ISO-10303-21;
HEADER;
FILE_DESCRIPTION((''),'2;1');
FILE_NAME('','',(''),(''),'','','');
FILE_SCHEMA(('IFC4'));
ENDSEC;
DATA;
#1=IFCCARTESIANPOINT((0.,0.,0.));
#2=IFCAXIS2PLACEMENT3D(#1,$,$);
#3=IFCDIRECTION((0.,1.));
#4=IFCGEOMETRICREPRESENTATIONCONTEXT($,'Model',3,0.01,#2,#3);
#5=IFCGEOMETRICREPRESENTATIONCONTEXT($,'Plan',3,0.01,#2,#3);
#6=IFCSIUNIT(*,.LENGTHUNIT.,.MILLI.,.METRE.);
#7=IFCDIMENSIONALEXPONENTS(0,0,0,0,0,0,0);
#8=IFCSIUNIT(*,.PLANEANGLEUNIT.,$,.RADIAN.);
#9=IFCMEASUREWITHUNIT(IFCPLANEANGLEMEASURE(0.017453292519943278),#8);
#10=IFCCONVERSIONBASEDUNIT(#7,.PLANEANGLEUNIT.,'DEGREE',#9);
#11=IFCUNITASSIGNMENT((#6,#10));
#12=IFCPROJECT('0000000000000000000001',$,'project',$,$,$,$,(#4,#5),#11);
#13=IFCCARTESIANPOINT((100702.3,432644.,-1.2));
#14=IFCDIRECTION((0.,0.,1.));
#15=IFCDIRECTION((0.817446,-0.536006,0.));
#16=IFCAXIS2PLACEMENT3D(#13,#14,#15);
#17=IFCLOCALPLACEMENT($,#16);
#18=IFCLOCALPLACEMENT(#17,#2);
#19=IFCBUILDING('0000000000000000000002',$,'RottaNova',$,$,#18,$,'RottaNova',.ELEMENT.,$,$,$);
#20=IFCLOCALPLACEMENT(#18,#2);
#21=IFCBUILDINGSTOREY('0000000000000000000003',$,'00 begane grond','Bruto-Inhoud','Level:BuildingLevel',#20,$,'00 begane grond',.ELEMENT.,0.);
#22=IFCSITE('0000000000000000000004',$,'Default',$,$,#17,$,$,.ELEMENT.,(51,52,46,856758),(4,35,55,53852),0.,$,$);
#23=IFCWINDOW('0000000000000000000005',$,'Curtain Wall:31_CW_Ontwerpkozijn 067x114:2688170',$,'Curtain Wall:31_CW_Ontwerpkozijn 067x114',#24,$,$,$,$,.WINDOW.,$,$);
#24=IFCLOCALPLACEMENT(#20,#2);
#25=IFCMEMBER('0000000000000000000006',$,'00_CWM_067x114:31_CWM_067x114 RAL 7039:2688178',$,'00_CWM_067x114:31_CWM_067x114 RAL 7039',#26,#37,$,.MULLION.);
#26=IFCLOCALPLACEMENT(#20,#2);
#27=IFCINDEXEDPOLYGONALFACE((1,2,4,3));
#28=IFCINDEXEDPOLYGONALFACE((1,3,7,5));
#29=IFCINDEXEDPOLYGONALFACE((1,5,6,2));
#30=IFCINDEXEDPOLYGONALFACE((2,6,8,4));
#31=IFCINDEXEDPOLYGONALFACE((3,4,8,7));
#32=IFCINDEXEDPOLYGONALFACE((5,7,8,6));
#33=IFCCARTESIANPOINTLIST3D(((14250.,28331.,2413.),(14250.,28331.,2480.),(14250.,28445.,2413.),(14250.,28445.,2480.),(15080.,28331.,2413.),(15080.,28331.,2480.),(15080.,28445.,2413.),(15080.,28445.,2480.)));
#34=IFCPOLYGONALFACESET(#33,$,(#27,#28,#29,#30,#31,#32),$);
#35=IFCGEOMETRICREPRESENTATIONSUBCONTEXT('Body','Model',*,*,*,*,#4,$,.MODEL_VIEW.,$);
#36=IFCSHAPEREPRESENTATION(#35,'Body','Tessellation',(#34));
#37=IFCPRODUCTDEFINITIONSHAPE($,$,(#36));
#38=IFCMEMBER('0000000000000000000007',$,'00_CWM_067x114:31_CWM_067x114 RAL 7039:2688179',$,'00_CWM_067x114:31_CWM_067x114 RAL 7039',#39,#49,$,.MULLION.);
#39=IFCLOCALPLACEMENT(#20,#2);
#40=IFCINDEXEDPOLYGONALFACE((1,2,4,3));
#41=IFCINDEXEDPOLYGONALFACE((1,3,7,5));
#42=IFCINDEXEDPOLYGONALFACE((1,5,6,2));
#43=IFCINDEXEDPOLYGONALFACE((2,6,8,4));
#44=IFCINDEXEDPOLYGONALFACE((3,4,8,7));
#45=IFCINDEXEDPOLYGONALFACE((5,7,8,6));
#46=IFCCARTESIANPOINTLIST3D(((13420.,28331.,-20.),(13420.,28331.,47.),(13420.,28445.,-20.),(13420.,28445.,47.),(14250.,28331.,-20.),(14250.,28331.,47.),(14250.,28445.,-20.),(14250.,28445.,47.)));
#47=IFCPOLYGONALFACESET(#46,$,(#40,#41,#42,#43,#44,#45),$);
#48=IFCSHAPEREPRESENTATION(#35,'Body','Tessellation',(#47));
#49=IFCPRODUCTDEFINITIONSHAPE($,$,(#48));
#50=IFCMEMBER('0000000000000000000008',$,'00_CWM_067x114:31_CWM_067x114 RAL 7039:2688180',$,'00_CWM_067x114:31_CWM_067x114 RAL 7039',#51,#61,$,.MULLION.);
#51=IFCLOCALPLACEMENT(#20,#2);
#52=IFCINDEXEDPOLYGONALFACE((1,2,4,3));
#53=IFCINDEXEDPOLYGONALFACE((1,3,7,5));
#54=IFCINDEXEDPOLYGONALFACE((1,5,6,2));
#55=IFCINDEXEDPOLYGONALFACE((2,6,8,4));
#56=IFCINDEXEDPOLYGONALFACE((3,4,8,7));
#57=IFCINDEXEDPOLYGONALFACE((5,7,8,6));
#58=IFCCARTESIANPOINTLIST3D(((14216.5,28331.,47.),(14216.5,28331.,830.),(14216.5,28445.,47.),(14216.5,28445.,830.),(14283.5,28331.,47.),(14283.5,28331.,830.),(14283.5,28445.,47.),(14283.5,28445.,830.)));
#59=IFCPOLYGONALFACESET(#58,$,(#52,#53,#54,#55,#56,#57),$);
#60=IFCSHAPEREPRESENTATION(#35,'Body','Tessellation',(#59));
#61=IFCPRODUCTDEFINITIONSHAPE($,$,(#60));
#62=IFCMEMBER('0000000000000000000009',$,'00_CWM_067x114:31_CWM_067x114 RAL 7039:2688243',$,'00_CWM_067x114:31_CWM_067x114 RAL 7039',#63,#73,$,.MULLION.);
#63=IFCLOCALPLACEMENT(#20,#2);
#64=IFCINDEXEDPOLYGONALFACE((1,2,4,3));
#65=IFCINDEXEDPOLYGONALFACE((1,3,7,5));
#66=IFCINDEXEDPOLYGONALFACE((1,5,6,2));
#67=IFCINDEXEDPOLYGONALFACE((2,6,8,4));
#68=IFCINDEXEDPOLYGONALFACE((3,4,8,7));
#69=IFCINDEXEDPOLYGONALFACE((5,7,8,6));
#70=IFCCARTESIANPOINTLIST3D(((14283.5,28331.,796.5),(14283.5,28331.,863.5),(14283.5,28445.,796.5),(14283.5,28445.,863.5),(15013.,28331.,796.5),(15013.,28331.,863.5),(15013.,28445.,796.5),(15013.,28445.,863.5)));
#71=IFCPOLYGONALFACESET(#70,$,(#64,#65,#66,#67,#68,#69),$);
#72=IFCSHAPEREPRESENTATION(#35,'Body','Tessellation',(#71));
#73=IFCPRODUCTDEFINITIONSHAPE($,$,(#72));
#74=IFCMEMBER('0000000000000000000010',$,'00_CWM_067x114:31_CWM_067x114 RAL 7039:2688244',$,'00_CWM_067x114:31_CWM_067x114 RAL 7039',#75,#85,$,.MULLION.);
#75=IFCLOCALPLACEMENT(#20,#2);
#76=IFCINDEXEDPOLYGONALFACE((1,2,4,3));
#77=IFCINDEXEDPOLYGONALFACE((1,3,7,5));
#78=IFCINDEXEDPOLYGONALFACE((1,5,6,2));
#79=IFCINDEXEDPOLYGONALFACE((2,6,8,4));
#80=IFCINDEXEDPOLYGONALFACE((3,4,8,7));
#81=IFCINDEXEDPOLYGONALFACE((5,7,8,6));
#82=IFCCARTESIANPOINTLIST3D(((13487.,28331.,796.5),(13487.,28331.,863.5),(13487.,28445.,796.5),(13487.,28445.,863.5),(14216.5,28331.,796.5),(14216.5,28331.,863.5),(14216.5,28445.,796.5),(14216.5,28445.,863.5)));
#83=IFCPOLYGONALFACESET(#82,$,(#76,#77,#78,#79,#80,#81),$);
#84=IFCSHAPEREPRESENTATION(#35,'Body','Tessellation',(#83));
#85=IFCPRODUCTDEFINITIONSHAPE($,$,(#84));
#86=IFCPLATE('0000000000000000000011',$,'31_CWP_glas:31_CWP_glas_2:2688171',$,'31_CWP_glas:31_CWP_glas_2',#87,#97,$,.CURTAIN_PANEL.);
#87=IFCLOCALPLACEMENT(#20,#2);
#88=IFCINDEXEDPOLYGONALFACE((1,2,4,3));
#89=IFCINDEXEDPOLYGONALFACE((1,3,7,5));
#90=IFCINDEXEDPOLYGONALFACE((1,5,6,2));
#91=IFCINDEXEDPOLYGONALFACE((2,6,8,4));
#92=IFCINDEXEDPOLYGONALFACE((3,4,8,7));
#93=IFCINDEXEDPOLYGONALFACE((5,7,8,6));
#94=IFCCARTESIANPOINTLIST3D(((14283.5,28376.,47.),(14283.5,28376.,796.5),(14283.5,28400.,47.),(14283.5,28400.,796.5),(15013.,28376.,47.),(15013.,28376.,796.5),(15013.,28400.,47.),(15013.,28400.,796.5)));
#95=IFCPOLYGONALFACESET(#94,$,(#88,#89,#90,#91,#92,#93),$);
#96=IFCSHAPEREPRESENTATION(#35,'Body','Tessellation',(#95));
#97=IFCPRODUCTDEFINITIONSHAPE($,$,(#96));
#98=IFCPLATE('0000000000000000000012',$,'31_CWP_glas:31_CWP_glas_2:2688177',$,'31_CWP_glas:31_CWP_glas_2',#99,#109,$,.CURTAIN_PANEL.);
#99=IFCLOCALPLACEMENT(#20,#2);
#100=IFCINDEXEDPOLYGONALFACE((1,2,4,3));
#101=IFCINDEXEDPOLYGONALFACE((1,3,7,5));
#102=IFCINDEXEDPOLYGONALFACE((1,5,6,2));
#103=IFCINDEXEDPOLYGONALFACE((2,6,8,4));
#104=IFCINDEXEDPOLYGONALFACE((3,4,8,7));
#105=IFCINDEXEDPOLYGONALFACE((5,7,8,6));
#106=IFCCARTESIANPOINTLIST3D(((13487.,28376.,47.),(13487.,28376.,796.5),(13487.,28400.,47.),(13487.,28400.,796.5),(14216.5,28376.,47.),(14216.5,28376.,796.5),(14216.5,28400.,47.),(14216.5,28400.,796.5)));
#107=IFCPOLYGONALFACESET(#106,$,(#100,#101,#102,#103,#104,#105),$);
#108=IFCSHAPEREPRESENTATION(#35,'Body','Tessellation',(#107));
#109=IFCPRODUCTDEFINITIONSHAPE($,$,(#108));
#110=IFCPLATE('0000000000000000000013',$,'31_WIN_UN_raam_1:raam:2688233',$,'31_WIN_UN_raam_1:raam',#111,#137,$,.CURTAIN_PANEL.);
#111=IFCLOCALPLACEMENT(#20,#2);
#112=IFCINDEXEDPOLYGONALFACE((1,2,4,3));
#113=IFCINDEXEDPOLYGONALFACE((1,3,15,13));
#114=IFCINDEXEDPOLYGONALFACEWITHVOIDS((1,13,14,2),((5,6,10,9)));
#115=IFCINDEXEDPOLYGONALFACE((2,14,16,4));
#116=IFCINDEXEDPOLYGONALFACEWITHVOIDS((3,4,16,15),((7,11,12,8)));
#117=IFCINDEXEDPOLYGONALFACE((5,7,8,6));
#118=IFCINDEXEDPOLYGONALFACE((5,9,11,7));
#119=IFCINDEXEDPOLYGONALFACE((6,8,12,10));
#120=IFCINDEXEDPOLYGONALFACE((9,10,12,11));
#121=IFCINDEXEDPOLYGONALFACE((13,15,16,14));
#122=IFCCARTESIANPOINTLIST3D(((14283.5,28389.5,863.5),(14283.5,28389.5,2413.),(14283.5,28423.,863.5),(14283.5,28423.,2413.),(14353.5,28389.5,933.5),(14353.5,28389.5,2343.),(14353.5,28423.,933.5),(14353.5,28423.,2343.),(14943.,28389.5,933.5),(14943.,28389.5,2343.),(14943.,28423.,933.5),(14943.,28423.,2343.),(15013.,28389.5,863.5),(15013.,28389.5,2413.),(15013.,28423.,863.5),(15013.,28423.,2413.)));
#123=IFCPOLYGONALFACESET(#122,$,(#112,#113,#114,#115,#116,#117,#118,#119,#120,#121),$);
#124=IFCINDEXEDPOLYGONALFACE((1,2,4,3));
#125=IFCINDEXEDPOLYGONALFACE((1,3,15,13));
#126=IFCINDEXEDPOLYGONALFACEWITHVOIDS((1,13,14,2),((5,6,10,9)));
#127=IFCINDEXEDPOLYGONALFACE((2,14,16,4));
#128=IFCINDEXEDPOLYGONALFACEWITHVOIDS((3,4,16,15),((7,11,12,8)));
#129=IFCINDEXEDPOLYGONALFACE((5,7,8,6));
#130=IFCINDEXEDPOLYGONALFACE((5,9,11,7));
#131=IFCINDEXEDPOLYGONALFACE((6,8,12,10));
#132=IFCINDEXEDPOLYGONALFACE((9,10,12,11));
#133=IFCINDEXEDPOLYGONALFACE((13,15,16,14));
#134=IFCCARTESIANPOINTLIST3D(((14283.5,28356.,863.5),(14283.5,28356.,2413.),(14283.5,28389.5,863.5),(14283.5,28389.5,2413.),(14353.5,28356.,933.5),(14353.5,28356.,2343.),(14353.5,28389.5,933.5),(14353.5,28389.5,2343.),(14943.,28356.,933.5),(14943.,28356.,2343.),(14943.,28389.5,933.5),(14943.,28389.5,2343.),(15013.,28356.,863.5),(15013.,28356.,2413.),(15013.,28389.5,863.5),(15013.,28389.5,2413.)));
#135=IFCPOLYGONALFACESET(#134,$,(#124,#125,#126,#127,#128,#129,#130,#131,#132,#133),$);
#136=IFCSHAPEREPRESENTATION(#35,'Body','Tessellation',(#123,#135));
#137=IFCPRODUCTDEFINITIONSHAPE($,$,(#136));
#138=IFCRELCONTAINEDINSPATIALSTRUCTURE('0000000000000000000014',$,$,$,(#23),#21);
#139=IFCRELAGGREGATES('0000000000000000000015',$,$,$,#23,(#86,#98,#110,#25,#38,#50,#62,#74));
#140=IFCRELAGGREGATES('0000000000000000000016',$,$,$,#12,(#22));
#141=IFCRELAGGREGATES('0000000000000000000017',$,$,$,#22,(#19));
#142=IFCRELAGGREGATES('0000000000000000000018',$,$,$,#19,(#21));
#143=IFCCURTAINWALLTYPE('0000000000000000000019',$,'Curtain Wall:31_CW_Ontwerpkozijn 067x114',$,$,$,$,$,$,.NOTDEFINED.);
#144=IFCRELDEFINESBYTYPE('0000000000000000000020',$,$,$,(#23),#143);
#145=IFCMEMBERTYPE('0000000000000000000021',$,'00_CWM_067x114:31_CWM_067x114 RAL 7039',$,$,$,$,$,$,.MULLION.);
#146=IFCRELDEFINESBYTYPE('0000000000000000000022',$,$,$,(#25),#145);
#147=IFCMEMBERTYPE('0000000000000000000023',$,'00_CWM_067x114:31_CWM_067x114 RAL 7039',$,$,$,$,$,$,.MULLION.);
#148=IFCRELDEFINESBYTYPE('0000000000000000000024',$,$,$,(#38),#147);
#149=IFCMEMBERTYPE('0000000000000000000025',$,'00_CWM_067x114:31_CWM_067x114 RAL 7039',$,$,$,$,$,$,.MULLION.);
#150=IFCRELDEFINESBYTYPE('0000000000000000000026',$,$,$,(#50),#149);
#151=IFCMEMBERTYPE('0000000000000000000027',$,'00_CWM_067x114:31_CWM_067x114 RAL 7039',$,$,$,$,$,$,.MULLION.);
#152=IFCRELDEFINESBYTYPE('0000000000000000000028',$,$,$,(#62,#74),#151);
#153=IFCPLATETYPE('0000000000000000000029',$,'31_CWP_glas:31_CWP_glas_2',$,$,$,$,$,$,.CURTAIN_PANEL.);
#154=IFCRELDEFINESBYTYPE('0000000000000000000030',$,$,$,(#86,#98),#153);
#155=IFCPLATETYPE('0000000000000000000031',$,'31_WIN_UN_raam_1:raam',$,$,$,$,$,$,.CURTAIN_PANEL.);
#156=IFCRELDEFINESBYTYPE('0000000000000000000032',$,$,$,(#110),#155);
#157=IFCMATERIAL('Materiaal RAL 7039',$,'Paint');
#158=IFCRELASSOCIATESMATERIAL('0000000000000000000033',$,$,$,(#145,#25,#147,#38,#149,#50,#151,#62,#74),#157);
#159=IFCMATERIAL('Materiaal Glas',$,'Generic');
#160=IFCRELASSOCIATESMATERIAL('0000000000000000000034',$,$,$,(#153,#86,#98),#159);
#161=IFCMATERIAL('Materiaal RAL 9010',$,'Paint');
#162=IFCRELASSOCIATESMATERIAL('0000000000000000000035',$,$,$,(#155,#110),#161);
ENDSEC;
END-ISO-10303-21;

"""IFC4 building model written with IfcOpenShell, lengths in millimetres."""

from ifc_helpers import new_model, entity, si_unit, converted_unit, direction, frame, origin, place, context, subcontext, project, spatial, indexed_curve, outline, extrude, source, transform, mapped, material, type_object, type_shapes, element, aggregate, save


model = new_model("IFC4")

# Units and contexts
model_context = context("Model", 3, precision=0.01, world=origin(), true_north=direction((0.0, 1.0)))
plan_context = context("Plan", 3, precision=0.01, world=origin(), true_north=direction((0.0, 1.0)))
body_context = subcontext(model_context, "Body", "Model", "MODEL_VIEW")
ifc_project = project(units=[si_unit("LENGTHUNIT", "METRE", prefix="MILLI"), converted_unit("PLANEANGLEUNIT", "DEGREE", entity("IfcPlaneAngleMeasure", 0.017453292519943278), si_unit("PLANEANGLEUNIT", "RADIAN"), dimensions=[0, 0, 0, 0, 0, 0, 0])], contexts=[model_context, plan_context])

# Site, building, storey
site_placement = place(None, frame((100702.3, 432644.0, -1.2), z_axis=(0.0, 0.0, 1.0), x_axis=(0.817446, -0.536006, 0.0)))
site = spatial("IfcSite", under=ifc_project, at=site_placement, Name="Default", CompositionType="ELEMENT", RefLatitude=(51, 52, 46, 856758), RefLongitude=(4, 35, 55, 53852), RefElevation=0.0)
building_placement = place(site_placement, origin())
building = spatial("IfcBuilding", under=site, at=building_placement, Name="RottaNova", LongName="RottaNova", CompositionType="ELEMENT")
storey_placement = place(building_placement, origin())
storey = spatial("IfcBuildingStorey", under=building, at=storey_placement, Name="00 begane grond", Description="Bruto-Inhoud", ObjectType="Level:BuildingLevel", LongName="00 begane grond", CompositionType="ELEMENT", Elevation=0.0)

# Shared definitions
curtain_wall_type = type_object("IfcCurtainWallType", Name="Curtain Wall:31_CW_Ontwerpkozijn 067x114", PredefinedType="NOTDEFINED")
ifc_material_1 = material(Name="Materiaal RAL 7039", Category="Paint")

# Window
window_1_placement = place(storey_placement, origin())
window_1 = element("IfcWindow", 1, at=window_1_placement, inside=storey, type_object=curtain_wall_type, Name="Curtain Wall:31_CW_Ontwerpkozijn 067x114:2688170", ObjectType="Curtain Wall:31_CW_Ontwerpkozijn 067x114", PredefinedType="WINDOW")

# Members
member_type_1 = type_object("IfcMemberType", Name="00_CWM_067x114:31_CWM_067x114 RAL 7039", PredefinedType="MULLION", material=ifc_material_1)
shared_shape_1 = source(origin(), body_context, "Body", "SweptSolid", [
    extrude(outline(indexed_curve([(-33.5, -57.0), (33.5, -57.0), (33.5, 57.0), (-33.5, 57.0), (-33.5, -57.0)], self_intersect=False)), frame((-33.5, 57.0, -830.0), z_axis=(0.0, 0.0, 1.0), x_axis=(-1.0, 0.0, 0.0)), (0.0, 0.0, 1.0), 830.0),
])
type_shapes(member_type_1, [shared_shape_1])
member_1_placement = place(window_1_placement, frame((14250.0, 28331.0, 2480.0), z_axis=(-1.0, 0.0, 0.0), x_axis=(0.0, 0.0, 1.0)))
member_1 = element("IfcMember", 2, at=member_1_placement, type_object=member_type_1, material=ifc_material_1, Name="00_CWM_067x114:31_CWM_067x114 RAL 7039:2688178", ObjectType="00_CWM_067x114:31_CWM_067x114 RAL 7039", PredefinedType="MULLION", context=body_context, shape_type="MappedRepresentation", body=[
    mapped(shared_shape_1, transform((0.0, 0.0, 0.0), scale=1.0)),
])
member_type_2 = type_object("IfcMemberType", Name="00_CWM_067x114:31_CWM_067x114 RAL 7039", PredefinedType="MULLION", material=ifc_material_1)
shared_shape_2 = source(origin(), body_context, "Body", "SweptSolid", [
    extrude(outline(indexed_curve([(-33.5, -57.0), (33.5, -57.0), (33.5, 57.0), (-33.5, 57.0), (-33.5, -57.0)], self_intersect=False)), frame((-33.5, 57.0, -830.0), z_axis=(0.0, 0.0, 1.0), x_axis=(-1.0, 0.0, 0.0)), (0.0, 0.0, 1.0), 830.0),
])
type_shapes(member_type_2, [shared_shape_2])
member_2_placement = place(window_1_placement, frame((14250.0, 28331.0, -20.0), z_axis=(1.0, 0.0, 0.0), x_axis=(0.0, 0.0, -1.0)))
member_2 = element("IfcMember", 3, at=member_2_placement, type_object=member_type_2, material=ifc_material_1, Name="00_CWM_067x114:31_CWM_067x114 RAL 7039:2688179", ObjectType="00_CWM_067x114:31_CWM_067x114 RAL 7039", PredefinedType="MULLION", context=body_context, shape_type="MappedRepresentation", body=[
    mapped(shared_shape_2, transform((0.0, 0.0, 0.0), scale=1.0)),
])
member_type_3 = type_object("IfcMemberType", Name="00_CWM_067x114:31_CWM_067x114 RAL 7039", PredefinedType="MULLION", material=ifc_material_1)
shared_shape_3 = source(origin(), body_context, "Body", "SweptSolid", [
    extrude(outline(indexed_curve([(-33.5, -57.0), (33.5, -57.0), (33.5, 57.0), (-33.5, 57.0), (-33.5, -57.0)], self_intersect=False)), frame((0.0, 57.0, -783.0), z_axis=(0.0, 0.0, 1.0), x_axis=(-1.0, 0.0, 0.0)), (0.0, 0.0, 1.0), 783.0),
])
type_shapes(member_type_3, [shared_shape_3])
member_3_placement = place(window_1_placement, frame((14250.0, 28331.0, 47.0), z_axis=(0.0, 0.0, -1.0), x_axis=(-1.0, 0.0, 0.0)))
member_3 = element("IfcMember", 4, at=member_3_placement, type_object=member_type_3, material=ifc_material_1, Name="00_CWM_067x114:31_CWM_067x114 RAL 7039:2688180", ObjectType="00_CWM_067x114:31_CWM_067x114 RAL 7039", PredefinedType="MULLION", context=body_context, shape_type="MappedRepresentation", body=[
    mapped(shared_shape_3, transform((0.0, 0.0, 0.0), scale=1.0)),
])
member_type_4 = type_object("IfcMemberType", Name="00_CWM_067x114:31_CWM_067x114 RAL 7039", PredefinedType="MULLION", material=ifc_material_1)
shared_shape_4 = source(origin(), body_context, "Body", "SweptSolid", [
    extrude(outline(indexed_curve([(-33.5, -57.0), (33.5, -57.0), (33.5, 57.0), (-33.5, 57.0), (-33.5, -57.0)], self_intersect=False)), frame((0.0, 57.0, -729.5), z_axis=(0.0, 0.0, 1.0), x_axis=(-1.0, 0.0, 0.0)), (0.0, 0.0, 1.0), 729.5),
])
type_shapes(member_type_4, [shared_shape_4])
member_4_placement = place(window_1_placement, frame((14283.5, 28331.0, 830.0), z_axis=(-1.0, 0.0, 0.0), x_axis=(0.0, 0.0, 1.0)))
member_4 = element("IfcMember", 5, at=member_4_placement, type_object=member_type_4, material=ifc_material_1, Name="00_CWM_067x114:31_CWM_067x114 RAL 7039:2688243", ObjectType="00_CWM_067x114:31_CWM_067x114 RAL 7039", PredefinedType="MULLION", context=body_context, shape_type="MappedRepresentation", body=[
    mapped(shared_shape_4, transform((0.0, 0.0, 0.0), scale=1.0)),
])
member_5_placement = place(window_1_placement, frame((13487.0, 28331.0, 830.0), z_axis=(-1.0, 0.0, 0.0), x_axis=(0.0, 0.0, 1.0)))
member_5 = element("IfcMember", 6, at=member_5_placement, type_object=member_type_4, material=ifc_material_1, Name="00_CWM_067x114:31_CWM_067x114 RAL 7039:2688244", ObjectType="00_CWM_067x114:31_CWM_067x114 RAL 7039", PredefinedType="MULLION", context=body_context, shape_type="MappedRepresentation", body=[
    mapped(shared_shape_4, transform((0.0, 0.0, 0.0), scale=1.0)),
])

# Plates
ifc_material_2 = material(Name="Materiaal Glas", Category="Generic")
plate_type_1 = type_object("IfcPlateType", Name="31_CWP_glas:31_CWP_glas_2", PredefinedType="CURTAIN_PANEL", material=ifc_material_2)
shared_shape_5 = source(origin(), body_context, "Body", "SweptSolid", [
    extrude(outline(indexed_curve([(-12.0, -364.7), (12.0, -364.7), (12.0, 364.7), (-12.0, 364.7), (-12.0, -364.7)], self_intersect=False)), frame((0.0, -57.0, 0.0), z_axis=(0.0, 0.0, 1.0), x_axis=(0.0, 1.0, 0.0)), (0.0, 0.0, 1.0), 749.5),
])
type_shapes(plate_type_1, [shared_shape_5])
plate_1_placement = place(window_1_placement, frame((14648.3, 28331.0, 47.0), z_axis=(0.0, 0.0, 1.0), x_axis=(-1.0, 0.0, 0.0)))
plate_1 = element("IfcPlate", 7, at=plate_1_placement, type_object=plate_type_1, material=ifc_material_2, Name="31_CWP_glas:31_CWP_glas_2:2688171", ObjectType="31_CWP_glas:31_CWP_glas_2", PredefinedType="CURTAIN_PANEL", context=body_context, shape_type="MappedRepresentation", body=[
    mapped(shared_shape_5, transform((0.0, 0.0, 0.0), scale=1.0)),
])
plate_2_placement = place(window_1_placement, frame((13851.8, 28331.0, 47.0), z_axis=(0.0, 0.0, 1.0), x_axis=(-1.0, 0.0, 0.0)))
plate_2 = element("IfcPlate", 8, at=plate_2_placement, type_object=plate_type_1, material=ifc_material_2, Name="31_CWP_glas:31_CWP_glas_2:2688177", ObjectType="31_CWP_glas:31_CWP_glas_2", PredefinedType="CURTAIN_PANEL", context=body_context, shape_type="MappedRepresentation", body=[
    mapped(shared_shape_5, transform((0.0, 0.0, 0.0), scale=1.0)),
])
ifc_material_3 = material(Name="Materiaal RAL 9010", Category="Paint")
plate_type_2 = type_object("IfcPlateType", Name="31_WIN_UN_raam_1:raam", PredefinedType="CURTAIN_PANEL", material=ifc_material_3)
shared_shape_6 = source(origin(), body_context, "Body", "SweptSolid", [
    extrude(outline(indexed_curve([(-364.7, -774.7), (364.7, -774.7), (364.7, 774.7), (-364.7, 774.7), (-364.7, -774.7)], self_intersect=False), holes=[indexed_curve([(-294.7, 704.7), (294.7, 704.7), (294.7, -704.8), (-294.7, -704.8), (-294.7, 704.7)], self_intersect=False)]), frame((0.0, -92.0, 774.8), z_axis=(0.0, 1.0, 0.0), x_axis=(1.0, 0.0, 0.0)), (0.0, 0.0, 1.0), 33.5),
    extrude(outline(indexed_curve([(-364.7, -774.7), (364.7, -774.7), (364.7, 774.7), (-364.7, 774.7), (-364.7, -774.7)], self_intersect=False), holes=[indexed_curve([(-294.7, 704.7), (294.7, 704.7), (294.7, -704.8), (-294.7, -704.8), (-294.7, 704.7)], self_intersect=False)]), frame((0.0, -58.5, 774.8), z_axis=(0.0, 1.0, 0.0), x_axis=(1.0, 0.0, 0.0)), (0.0, 0.0, 1.0), 33.5),
])
type_shapes(plate_type_2, [shared_shape_6])
plate_3_placement = place(window_1_placement, frame((14648.3, 28331.0, 863.5), z_axis=(0.0, 0.0, 1.0), x_axis=(-1.0, 0.0, 0.0)))
plate_3 = element("IfcPlate", 9, at=plate_3_placement, type_object=plate_type_2, material=ifc_material_3, Name="31_WIN_UN_raam_1:raam:2688233", ObjectType="31_WIN_UN_raam_1:raam", PredefinedType="CURTAIN_PANEL", context=body_context, shape_type="MappedRepresentation", body=[
    mapped(shared_shape_6, transform((0.0, 0.0, 0.0), scale=1.0)),
])
aggregate(window_1, [plate_1, plate_2, plate_3, member_1, member_2, member_3, member_4, member_5])

save(model, "model.ifc")
